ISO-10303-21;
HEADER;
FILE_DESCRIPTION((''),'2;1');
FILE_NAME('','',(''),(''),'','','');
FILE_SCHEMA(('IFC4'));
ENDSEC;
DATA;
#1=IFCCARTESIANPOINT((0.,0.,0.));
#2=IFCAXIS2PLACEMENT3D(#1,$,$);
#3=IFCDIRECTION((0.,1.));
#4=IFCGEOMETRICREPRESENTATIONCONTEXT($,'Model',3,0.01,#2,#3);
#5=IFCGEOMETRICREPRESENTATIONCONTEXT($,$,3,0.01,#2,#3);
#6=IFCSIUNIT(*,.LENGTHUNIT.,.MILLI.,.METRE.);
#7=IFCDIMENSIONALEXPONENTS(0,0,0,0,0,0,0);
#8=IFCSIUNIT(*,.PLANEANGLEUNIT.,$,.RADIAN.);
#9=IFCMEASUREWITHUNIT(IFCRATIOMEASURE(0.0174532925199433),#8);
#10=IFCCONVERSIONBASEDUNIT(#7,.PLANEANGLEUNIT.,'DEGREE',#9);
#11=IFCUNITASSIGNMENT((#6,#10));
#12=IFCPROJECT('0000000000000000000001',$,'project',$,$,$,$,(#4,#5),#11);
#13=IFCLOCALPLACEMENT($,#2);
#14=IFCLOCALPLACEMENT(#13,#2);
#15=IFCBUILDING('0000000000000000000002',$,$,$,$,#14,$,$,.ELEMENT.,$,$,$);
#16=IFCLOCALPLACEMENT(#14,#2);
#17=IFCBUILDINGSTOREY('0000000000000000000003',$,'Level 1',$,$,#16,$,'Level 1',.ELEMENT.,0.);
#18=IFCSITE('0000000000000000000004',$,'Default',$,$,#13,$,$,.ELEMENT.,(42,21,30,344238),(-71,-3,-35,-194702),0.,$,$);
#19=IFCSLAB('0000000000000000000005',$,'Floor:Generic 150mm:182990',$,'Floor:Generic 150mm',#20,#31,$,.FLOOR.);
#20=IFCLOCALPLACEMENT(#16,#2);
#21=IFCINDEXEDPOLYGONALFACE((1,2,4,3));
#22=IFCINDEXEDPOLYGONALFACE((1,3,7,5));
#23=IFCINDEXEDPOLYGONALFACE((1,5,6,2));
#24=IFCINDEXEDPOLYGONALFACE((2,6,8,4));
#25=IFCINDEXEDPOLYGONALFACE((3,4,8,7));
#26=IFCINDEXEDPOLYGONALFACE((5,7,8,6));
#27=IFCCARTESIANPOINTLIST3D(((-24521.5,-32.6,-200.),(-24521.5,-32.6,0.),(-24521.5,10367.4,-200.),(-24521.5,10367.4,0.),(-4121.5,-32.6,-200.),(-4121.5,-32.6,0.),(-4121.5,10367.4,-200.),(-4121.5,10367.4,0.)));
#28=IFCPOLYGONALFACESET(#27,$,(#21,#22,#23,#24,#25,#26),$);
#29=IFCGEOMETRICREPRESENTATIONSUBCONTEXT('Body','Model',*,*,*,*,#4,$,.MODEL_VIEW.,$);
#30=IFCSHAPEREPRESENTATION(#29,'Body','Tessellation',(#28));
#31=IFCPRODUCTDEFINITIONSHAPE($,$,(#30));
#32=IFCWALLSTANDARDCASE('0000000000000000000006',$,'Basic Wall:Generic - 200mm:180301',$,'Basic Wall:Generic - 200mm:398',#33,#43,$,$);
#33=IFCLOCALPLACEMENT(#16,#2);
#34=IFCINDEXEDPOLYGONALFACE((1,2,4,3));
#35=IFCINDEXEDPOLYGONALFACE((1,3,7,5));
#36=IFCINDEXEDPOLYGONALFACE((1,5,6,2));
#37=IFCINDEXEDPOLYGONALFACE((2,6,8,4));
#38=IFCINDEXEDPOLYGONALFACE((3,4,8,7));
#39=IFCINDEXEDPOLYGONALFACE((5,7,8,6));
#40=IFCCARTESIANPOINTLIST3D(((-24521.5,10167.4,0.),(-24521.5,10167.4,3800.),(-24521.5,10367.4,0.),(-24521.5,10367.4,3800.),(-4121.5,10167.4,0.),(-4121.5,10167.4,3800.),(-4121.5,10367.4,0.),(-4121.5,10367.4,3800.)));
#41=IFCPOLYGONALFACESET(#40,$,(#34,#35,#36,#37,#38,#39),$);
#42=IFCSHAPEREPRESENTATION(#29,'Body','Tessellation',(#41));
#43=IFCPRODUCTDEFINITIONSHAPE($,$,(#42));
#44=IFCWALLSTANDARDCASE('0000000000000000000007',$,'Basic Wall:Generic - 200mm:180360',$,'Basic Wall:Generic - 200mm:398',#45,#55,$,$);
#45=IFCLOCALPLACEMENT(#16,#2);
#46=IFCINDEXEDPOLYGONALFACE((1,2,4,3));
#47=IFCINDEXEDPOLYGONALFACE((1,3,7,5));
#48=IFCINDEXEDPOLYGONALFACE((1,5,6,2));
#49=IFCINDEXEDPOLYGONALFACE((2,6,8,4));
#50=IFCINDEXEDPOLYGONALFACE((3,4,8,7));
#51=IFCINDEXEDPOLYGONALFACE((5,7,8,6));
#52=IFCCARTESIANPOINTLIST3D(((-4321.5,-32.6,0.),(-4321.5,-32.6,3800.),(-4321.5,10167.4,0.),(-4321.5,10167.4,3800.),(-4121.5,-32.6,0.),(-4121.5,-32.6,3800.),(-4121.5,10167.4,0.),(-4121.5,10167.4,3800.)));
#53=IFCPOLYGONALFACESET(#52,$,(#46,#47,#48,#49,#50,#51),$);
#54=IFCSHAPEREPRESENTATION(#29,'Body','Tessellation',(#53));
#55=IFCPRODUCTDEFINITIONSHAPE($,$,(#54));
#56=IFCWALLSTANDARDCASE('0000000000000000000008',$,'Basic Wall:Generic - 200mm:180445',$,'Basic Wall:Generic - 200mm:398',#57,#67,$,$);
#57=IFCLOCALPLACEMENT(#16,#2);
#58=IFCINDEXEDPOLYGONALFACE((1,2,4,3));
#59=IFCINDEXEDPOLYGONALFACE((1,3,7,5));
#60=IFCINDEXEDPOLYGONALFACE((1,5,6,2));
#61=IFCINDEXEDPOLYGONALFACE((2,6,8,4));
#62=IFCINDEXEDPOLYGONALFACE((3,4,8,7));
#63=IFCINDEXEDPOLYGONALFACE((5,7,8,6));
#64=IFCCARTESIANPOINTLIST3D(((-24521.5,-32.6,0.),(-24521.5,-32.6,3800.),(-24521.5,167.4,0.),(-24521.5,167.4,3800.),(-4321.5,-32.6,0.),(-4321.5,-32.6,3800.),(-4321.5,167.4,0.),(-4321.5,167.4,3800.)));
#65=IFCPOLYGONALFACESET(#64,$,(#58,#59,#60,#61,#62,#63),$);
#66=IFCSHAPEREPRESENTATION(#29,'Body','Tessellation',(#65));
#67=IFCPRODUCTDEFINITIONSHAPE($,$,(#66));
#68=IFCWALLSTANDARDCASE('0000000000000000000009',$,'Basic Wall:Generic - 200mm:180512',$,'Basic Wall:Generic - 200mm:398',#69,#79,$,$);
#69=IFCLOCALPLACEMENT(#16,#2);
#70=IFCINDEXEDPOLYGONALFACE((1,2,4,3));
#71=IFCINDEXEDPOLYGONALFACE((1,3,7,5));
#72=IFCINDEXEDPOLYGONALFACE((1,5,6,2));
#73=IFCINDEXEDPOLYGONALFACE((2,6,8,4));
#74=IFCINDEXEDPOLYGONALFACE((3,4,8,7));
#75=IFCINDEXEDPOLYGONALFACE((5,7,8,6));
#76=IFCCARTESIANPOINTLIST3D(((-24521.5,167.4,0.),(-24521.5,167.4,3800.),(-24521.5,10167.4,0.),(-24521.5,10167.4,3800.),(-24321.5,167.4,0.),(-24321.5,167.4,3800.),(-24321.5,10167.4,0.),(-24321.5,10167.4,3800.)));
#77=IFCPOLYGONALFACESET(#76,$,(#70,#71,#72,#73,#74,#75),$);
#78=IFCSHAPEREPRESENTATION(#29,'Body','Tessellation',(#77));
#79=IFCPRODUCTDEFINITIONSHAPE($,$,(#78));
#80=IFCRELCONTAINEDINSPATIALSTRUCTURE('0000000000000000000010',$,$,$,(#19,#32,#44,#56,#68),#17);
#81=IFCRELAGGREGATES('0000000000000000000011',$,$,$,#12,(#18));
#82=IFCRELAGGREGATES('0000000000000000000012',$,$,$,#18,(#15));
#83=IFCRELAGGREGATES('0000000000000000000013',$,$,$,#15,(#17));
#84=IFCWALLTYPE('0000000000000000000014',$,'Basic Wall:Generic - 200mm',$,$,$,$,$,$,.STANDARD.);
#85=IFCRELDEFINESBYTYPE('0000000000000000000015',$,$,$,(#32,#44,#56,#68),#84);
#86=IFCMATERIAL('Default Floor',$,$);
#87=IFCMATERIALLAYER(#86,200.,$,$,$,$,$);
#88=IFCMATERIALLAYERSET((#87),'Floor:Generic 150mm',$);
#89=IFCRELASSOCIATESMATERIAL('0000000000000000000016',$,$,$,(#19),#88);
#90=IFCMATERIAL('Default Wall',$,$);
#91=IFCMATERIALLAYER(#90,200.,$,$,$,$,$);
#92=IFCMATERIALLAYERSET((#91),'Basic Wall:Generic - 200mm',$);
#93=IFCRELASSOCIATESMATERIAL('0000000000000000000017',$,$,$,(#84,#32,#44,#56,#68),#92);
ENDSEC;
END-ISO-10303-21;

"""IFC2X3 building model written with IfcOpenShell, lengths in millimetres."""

from ifc_helpers import new_model, entity, si_unit, converted_unit, direction, frame, frame_2d, origin, place, context, subcontext, project, spatial, rectangle, extrude, material, layer, layer_set, layer_usage, type_object, element, save


model = new_model("IFC2X3")

# Units and contexts
model_context = context("Model", 3, precision=0.01, world=origin(), true_north=direction((0.0, 1.0)))
context_of_model = context(None, 3, precision=0.01, world=origin(), true_north=direction((0.0, 1.0)))
body_context = subcontext(model_context, "Body", "Model", "MODEL_VIEW")
ifc_project = project(units=[si_unit("LENGTHUNIT", "METRE", prefix="MILLI"), converted_unit("PLANEANGLEUNIT", "DEGREE", entity("IfcRatioMeasure", 0.0174532925199433), si_unit("PLANEANGLEUNIT", "RADIAN"), dimensions=[0, 0, 0, 0, 0, 0, 0])], contexts=[model_context, context_of_model])

# Site, building, storey
site_placement = place(None, origin())
site = spatial("IfcSite", under=ifc_project, at=site_placement, Name="Default", CompositionType="ELEMENT", RefLatitude=(42, 21, 30, 344238), RefLongitude=(-71, -3, -35, -194702), RefElevation=0.0)
building_placement = place(site_placement, origin())
building = spatial("IfcBuilding", under=site, at=building_placement, CompositionType="ELEMENT")
storey_placement = place(building_placement, origin())
storey = spatial("IfcBuildingStorey", under=building, at=storey_placement, Name="Level 1", LongName="Level 1", CompositionType="ELEMENT", Elevation=0.0)

# Slab
ifc_material_1 = material(Name="Default Floor")
ifc_layer_1 = layer(ifc_material_1, 200.0)
ifc_layer_set_1 = layer_set([ifc_layer_1], Name="Floor:Generic 150mm")
ifc_layer_usage_1 = layer_usage(ifc_layer_set_1, "AXIS3", "POSITIVE", 0.0)
slab_placement = place(storey_placement, origin())
element("IfcSlab", 1, at=slab_placement, inside=storey, material=ifc_layer_usage_1, Name="Floor:Generic 150mm:182990", ObjectType="Floor:Generic 150mm", PredefinedType="FLOOR", context=body_context, shape_type="SweptSolid", body=[
    extrude(rectangle(XDim=10400.0, YDim=20400.0, at=frame_2d((0.0, 0.0), x_axis=(1.0, 0.0))), frame((-14321.5, 5167.4, 0.0), z_axis=(0.0, 0.0, -1.0), x_axis=(0.0, 1.0, 0.0)), (0.0, 0.0, 1.0), 200.0),
])

# Walls
ifc_material_2 = material(Name="Default Wall")
ifc_layer_2 = layer(ifc_material_2, 200.0)
ifc_layer_set_2 = layer_set([ifc_layer_2], Name="Basic Wall:Generic - 200mm")
ifc_layer_usage_2 = layer_usage(ifc_layer_set_2, "AXIS2", "NEGATIVE", 100.0)
wall_type = type_object("IfcWallType", Name="Basic Wall:Generic - 200mm", PredefinedType="STANDARD", material=ifc_layer_set_2)
wall_1_placement = place(storey_placement, frame((-24521.5, 10267.4, 0.0)))
element("IfcWallStandardCase", 2, at=wall_1_placement, inside=storey, type_object=wall_type, material=ifc_layer_usage_2, Name="Basic Wall:Generic - 200mm:180301", ObjectType="Basic Wall:Generic - 200mm:398", context=body_context, shape_type="SweptSolid", body=[
    extrude(rectangle(XDim=20400.0, YDim=200.0, at=frame_2d((10200.0, 0.0), x_axis=(-1.0, 0.0))), origin(), (0.0, 0.0, 1.0), 3800.0),
])
ifc_layer_usage_3 = layer_usage(ifc_layer_set_2, "AXIS2", "NEGATIVE", 100.0)
wall_2_placement = place(storey_placement, frame((-4221.5, 10167.4, 0.0), z_axis=(0.0, 0.0, 1.0), x_axis=(0.0, -1.0, 0.0)))
element("IfcWallStandardCase", 3, at=wall_2_placement, inside=storey, type_object=wall_type, material=ifc_layer_usage_3, Name="Basic Wall:Generic - 200mm:180360", ObjectType="Basic Wall:Generic - 200mm:398", context=body_context, shape_type="SweptSolid", body=[
    extrude(rectangle(XDim=10200.0, YDim=200.0, at=frame_2d((5100.0, 0.0), x_axis=(-1.0, 0.0))), origin(), (0.0, 0.0, 1.0), 3800.0),
])
ifc_layer_usage_4 = layer_usage(ifc_layer_set_2, "AXIS2", "NEGATIVE", 100.0)
wall_3_placement = place(storey_placement, frame((-4321.5, 67.4, 0.0), z_axis=(0.0, 0.0, 1.0), x_axis=(-1.0, 0.0, 0.0)))
element("IfcWallStandardCase", 4, at=wall_3_placement, inside=storey, type_object=wall_type, material=ifc_layer_usage_4, Name="Basic Wall:Generic - 200mm:180445", ObjectType="Basic Wall:Generic - 200mm:398", context=body_context, shape_type="SweptSolid", body=[
    extrude(rectangle(XDim=20200.0, YDim=200.0, at=frame_2d((10100.0, 0.0), x_axis=(-1.0, 0.0))), origin(), (0.0, 0.0, 1.0), 3800.0),
])
ifc_layer_usage_5 = layer_usage(ifc_layer_set_2, "AXIS2", "NEGATIVE", 100.0)
wall_4_placement = place(storey_placement, frame((-24421.5, 167.4, 0.0), z_axis=(0.0, 0.0, 1.0), x_axis=(0.0, 1.0, 0.0)))
element("IfcWallStandardCase", 5, at=wall_4_placement, inside=storey, type_object=wall_type, material=ifc_layer_usage_5, Name="Basic Wall:Generic - 200mm:180512", ObjectType="Basic Wall:Generic - 200mm:398", context=body_context, shape_type="SweptSolid", body=[
    extrude(rectangle(XDim=10000.0, YDim=200.0, at=frame_2d((5000.0, 0.0), x_axis=(-1.0, 0.0))), origin(), (0.0, 0.0, 1.0), 3800.0),
])

save(model, "model.ifc")
